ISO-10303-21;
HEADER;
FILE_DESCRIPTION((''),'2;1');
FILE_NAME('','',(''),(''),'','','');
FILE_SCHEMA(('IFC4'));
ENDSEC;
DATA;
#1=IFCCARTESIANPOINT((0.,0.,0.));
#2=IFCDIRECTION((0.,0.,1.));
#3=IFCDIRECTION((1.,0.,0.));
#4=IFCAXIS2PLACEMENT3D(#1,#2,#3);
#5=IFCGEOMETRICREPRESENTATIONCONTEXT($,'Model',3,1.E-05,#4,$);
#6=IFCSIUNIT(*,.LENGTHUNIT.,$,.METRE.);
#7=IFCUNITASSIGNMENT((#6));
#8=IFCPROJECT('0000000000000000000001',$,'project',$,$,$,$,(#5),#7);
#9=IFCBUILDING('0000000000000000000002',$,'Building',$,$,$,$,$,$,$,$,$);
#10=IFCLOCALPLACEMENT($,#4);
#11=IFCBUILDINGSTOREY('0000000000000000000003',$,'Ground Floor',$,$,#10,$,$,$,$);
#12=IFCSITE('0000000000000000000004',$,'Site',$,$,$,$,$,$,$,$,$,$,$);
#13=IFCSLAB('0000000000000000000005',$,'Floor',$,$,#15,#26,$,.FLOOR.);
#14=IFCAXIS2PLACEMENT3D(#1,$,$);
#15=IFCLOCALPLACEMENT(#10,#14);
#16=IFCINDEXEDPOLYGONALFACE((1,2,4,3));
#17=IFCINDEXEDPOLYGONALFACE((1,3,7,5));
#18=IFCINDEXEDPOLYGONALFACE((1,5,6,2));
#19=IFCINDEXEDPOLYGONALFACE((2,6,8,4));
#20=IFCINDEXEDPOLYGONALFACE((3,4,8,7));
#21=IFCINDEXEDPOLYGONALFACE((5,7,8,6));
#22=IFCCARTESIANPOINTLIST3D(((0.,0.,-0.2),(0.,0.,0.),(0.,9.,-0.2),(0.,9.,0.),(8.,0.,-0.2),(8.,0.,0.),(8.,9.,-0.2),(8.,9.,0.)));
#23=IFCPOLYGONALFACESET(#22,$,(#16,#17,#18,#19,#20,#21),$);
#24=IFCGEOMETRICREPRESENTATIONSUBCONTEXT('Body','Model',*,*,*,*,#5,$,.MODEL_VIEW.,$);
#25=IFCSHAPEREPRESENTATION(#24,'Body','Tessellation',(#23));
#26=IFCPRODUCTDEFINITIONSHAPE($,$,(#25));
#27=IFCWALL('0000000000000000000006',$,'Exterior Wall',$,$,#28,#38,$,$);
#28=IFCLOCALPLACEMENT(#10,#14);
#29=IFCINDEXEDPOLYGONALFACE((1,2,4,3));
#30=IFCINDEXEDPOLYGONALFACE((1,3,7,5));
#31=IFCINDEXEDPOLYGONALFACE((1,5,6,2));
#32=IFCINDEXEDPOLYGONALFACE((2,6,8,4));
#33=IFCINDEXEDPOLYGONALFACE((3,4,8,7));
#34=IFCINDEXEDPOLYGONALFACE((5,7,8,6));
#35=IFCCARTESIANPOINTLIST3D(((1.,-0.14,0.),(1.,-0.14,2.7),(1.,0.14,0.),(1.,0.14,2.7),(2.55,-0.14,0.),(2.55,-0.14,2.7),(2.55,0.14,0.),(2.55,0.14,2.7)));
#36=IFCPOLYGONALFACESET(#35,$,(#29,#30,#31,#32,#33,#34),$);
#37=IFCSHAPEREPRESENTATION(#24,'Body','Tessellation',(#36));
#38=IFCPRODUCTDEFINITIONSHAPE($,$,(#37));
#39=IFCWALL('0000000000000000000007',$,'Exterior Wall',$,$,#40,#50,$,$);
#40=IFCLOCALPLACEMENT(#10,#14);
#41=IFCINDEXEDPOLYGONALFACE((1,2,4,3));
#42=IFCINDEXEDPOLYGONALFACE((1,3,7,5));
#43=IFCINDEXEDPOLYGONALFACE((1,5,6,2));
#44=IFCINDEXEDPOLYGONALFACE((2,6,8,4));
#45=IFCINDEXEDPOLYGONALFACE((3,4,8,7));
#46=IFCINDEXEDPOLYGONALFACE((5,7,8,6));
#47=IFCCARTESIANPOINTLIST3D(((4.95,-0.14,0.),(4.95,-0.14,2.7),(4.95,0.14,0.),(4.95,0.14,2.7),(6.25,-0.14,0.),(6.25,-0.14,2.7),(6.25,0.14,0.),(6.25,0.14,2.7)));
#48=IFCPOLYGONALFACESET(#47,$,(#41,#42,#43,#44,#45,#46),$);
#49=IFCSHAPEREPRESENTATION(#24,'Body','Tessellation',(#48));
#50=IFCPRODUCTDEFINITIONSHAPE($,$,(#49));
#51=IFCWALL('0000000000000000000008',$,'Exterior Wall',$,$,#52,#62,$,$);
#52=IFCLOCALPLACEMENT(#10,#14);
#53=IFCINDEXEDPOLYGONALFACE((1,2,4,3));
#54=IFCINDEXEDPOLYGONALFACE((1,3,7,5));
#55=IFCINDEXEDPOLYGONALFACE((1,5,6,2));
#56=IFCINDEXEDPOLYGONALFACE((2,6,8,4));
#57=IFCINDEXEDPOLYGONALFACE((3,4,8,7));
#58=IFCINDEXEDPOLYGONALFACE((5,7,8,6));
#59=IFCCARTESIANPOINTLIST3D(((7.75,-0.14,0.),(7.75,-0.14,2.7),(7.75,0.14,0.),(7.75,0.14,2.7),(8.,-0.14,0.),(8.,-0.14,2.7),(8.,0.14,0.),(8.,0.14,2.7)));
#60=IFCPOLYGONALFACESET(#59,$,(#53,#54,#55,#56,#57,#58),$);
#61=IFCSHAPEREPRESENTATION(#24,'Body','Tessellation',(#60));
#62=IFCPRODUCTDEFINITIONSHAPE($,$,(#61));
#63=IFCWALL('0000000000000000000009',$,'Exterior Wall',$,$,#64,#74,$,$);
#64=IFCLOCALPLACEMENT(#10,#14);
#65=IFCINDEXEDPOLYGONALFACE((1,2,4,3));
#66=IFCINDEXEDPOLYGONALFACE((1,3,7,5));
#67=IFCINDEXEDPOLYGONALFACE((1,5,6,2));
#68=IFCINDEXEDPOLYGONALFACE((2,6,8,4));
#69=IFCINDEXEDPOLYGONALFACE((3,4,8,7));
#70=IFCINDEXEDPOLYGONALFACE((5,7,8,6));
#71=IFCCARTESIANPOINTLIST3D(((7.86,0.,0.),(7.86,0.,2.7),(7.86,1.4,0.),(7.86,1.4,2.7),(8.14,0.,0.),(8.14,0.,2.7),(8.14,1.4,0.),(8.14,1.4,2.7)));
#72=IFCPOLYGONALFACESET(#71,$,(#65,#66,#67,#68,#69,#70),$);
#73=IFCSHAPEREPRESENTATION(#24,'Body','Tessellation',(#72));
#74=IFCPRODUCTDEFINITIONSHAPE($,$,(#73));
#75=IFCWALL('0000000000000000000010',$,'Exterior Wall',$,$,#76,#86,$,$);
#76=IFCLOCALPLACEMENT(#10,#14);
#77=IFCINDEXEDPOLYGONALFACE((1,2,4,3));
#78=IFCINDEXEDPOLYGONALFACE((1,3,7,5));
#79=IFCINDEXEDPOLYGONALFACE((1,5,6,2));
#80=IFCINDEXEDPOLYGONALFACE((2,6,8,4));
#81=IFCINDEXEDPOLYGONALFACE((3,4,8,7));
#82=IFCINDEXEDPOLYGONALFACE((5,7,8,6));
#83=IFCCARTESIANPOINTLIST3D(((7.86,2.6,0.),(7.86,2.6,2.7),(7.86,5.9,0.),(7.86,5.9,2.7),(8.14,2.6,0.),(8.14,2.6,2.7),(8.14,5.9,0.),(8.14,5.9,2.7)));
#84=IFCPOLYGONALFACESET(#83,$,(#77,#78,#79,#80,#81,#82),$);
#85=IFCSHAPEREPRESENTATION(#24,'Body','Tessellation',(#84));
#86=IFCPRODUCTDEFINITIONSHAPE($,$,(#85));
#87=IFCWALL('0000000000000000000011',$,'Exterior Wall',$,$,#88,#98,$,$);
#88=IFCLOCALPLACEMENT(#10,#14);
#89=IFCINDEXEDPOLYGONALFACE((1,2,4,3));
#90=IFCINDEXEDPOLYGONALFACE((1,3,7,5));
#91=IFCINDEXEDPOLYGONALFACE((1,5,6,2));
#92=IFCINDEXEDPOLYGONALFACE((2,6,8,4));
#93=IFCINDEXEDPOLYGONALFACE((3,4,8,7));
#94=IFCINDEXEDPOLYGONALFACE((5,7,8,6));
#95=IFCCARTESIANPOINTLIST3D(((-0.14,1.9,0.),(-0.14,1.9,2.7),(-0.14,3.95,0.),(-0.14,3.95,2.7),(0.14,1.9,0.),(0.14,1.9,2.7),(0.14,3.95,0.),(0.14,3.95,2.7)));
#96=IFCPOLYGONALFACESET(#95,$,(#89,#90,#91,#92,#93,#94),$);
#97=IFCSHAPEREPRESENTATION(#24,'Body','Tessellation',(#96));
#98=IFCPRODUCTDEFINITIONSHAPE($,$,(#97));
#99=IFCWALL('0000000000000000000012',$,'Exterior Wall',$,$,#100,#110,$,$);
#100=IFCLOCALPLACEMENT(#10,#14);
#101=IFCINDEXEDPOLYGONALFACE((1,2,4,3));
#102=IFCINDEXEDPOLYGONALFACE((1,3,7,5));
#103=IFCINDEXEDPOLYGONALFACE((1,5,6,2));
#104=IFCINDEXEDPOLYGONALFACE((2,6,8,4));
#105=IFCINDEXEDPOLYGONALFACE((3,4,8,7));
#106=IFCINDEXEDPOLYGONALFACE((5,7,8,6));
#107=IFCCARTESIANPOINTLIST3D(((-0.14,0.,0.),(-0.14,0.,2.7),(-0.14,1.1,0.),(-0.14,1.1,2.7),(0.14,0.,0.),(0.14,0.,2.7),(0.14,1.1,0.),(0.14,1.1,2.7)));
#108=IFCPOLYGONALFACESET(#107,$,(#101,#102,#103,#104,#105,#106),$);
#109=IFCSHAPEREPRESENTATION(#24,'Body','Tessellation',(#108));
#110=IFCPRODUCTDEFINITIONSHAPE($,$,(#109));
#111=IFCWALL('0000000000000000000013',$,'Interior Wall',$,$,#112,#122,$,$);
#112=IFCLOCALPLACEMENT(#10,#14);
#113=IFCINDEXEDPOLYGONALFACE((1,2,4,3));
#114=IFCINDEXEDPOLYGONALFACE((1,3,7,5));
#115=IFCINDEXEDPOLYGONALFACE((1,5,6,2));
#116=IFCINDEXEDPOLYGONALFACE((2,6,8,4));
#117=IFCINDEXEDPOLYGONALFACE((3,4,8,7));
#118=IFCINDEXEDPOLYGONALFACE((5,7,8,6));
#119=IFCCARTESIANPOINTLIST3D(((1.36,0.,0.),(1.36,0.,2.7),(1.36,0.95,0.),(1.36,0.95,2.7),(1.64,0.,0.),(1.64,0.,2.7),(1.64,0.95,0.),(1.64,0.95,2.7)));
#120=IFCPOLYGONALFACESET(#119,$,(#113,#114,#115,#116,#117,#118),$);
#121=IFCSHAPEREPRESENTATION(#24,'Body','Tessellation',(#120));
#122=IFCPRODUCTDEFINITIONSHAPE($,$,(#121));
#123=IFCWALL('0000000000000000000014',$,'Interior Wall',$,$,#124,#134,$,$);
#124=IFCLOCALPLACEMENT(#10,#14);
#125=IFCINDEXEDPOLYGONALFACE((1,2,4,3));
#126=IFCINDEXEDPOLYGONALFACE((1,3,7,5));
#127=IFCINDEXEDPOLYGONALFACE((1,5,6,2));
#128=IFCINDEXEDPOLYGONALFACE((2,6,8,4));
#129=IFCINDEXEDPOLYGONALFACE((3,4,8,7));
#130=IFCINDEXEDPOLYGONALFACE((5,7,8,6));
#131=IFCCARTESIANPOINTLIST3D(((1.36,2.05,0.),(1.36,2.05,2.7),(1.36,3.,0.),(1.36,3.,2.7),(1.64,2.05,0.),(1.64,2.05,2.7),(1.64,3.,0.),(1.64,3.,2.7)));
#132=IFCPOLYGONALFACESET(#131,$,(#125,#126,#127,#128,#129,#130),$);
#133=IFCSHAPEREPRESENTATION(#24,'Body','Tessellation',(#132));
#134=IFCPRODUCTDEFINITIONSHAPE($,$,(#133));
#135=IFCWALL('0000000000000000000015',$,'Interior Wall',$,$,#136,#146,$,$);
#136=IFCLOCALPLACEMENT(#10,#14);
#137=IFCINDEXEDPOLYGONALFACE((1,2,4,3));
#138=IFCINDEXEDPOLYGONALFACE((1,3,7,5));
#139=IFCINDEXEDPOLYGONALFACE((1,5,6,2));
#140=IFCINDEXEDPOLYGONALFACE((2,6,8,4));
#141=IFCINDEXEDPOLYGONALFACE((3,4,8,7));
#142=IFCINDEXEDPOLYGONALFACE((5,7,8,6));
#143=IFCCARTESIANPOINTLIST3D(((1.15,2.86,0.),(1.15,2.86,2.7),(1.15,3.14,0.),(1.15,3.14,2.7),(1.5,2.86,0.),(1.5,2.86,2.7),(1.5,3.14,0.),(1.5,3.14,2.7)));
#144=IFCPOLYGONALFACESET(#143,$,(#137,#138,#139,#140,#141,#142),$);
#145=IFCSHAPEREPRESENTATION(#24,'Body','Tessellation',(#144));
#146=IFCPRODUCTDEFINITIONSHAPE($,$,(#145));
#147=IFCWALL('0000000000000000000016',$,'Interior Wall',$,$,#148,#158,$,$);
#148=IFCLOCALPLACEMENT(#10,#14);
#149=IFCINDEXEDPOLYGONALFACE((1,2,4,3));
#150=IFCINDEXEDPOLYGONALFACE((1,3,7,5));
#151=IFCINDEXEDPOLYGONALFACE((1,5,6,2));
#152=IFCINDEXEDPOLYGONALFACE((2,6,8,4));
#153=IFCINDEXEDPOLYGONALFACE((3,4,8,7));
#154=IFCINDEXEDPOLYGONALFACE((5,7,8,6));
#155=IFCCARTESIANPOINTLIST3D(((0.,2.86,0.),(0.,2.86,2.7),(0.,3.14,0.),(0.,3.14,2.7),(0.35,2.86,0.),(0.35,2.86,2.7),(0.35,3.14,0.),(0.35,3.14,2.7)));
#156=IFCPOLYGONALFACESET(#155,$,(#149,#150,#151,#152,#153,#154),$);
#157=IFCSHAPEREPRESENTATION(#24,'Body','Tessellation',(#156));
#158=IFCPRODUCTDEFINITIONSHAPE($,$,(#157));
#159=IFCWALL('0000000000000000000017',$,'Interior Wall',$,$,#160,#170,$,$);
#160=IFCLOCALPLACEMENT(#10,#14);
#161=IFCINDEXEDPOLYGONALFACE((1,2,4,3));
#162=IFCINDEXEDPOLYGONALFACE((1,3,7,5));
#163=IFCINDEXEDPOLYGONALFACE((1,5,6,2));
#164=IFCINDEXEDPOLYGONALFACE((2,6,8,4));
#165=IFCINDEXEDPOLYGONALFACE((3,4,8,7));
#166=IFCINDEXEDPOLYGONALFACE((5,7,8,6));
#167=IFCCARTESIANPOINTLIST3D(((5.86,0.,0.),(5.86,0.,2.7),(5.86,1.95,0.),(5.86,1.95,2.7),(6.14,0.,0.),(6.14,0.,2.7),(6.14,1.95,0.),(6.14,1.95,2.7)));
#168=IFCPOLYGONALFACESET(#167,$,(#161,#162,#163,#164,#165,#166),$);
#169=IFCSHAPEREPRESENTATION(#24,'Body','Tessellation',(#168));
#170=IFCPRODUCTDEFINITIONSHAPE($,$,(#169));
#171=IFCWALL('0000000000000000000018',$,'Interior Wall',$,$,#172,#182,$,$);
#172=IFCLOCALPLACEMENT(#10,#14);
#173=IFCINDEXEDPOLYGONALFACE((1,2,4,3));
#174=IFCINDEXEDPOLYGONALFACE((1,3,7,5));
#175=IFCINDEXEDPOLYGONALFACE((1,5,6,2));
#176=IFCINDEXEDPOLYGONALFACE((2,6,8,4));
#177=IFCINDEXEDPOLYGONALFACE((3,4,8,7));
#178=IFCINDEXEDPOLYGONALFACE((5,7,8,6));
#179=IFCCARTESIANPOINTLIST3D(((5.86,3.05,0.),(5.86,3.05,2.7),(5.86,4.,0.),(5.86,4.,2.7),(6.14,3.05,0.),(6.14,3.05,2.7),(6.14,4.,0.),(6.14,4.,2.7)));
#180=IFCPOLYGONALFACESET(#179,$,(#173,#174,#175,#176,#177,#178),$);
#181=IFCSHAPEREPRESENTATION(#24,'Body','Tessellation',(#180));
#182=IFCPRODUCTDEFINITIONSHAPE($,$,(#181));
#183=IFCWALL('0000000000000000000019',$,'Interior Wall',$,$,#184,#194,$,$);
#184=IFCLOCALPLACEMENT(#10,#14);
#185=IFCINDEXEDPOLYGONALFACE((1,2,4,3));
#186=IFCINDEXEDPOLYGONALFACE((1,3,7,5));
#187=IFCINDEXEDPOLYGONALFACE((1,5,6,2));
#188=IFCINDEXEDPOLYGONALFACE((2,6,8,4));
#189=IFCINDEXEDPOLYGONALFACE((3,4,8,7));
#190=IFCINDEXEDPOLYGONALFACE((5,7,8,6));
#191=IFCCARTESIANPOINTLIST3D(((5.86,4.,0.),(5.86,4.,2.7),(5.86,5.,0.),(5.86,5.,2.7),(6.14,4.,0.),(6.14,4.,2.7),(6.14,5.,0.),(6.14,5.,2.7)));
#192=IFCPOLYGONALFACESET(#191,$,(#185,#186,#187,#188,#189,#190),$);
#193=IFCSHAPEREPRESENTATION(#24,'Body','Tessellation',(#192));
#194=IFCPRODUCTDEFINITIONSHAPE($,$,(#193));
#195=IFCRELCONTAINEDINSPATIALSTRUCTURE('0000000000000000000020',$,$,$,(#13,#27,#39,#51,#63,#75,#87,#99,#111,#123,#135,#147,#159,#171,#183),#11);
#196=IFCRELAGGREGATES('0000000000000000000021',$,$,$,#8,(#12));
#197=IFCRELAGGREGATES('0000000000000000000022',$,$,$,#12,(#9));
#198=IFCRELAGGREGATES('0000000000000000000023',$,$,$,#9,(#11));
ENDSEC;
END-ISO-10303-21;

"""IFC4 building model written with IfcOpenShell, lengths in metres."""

from ifc_helpers import new_model, si_unit, frame, origin_with_axes, place, context, subcontext, project, spatial, indexed_curve, outline, extrude, element, save


model = new_model("IFC4")

# Units and contexts
model_context = context("Model", 3, precision=1e-05, world=origin_with_axes())
body_context = subcontext(model_context, "Body", "Model", "MODEL_VIEW")
ifc_project = project(units=[si_unit("LENGTHUNIT", "METRE")], contexts=[model_context])

# Site, building, storey
site = spatial("IfcSite", under=ifc_project, Name="Site")
building = spatial("IfcBuilding", under=site, Name="Building")
storey_placement = place(None, origin_with_axes())
storey = spatial("IfcBuildingStorey", under=building, at=storey_placement, Name="Ground Floor")

# Slab
slab_placement = place(storey_placement, frame((0.0, 0.0, -0.2), z_axis=(0.0, 0.0, 1.0), x_axis=(1.0, 0.0, 0.0)))
element("IfcSlab", 1, at=slab_placement, inside=storey, Name="Floor", PredefinedType="FLOOR", context=body_context, shape_type="SweptSolid", body=[
    extrude(outline(indexed_curve([(0.0, 0.0), (8.0, 0.0), (8.0, 9.0), (0.0, 9.0)])), None, (0.0, 0.0, 1.0), 0.2),
])

# Walls
wall_1_placement = place(storey_placement, frame((1.0, 0.0, 0.0), z_axis=(0.0, 0.0, 1.0), x_axis=(1.0, 0.0, 0.0)))
element("IfcWall", 2, at=wall_1_placement, inside=storey, Name="Exterior Wall", context=body_context, shape_type="SweptSolid", body=[
    extrude(outline(indexed_curve([(0.0, 0.0), (0.0, 0.28), (1.55, 0.28), (1.55, 0.0), (0.0, 0.0)], self_intersect=False)), frame((0.0, -0.14, 0.0), z_axis=(0.0, 0.0, 1.0), x_axis=(1.0, 0.0, 0.0)), (0.0, 0.0, 1.0), 2.7),
])
wall_2_placement = place(storey_placement, frame((4.95, 0.0, 0.0), z_axis=(0.0, 0.0, 1.0), x_axis=(1.0, 0.0, 0.0)))
element("IfcWall", 3, at=wall_2_placement, inside=storey, Name="Exterior Wall", context=body_context, shape_type="SweptSolid", body=[
    extrude(outline(indexed_curve([(0.0, 0.0), (0.0, 0.28), (1.3, 0.28), (1.3, 0.0), (0.0, 0.0)], self_intersect=False)), frame((0.0, -0.14, 0.0), z_axis=(0.0, 0.0, 1.0), x_axis=(1.0, 0.0, 0.0)), (0.0, 0.0, 1.0), 2.7),
])
wall_3_placement = place(storey_placement, frame((7.75, 0.0, 0.0), z_axis=(0.0, 0.0, 1.0), x_axis=(1.0, 0.0, 0.0)))
element("IfcWall", 4, at=wall_3_placement, inside=storey, Name="Exterior Wall", context=body_context, shape_type="SweptSolid", body=[
    extrude(outline(indexed_curve([(0.0, 0.0), (0.0, 0.28), (0.25, 0.28), (0.25, 0.0), (0.0, 0.0)], self_intersect=False)), frame((0.0, -0.14, 0.0), z_axis=(0.0, 0.0, 1.0), x_axis=(1.0, 0.0, 0.0)), (0.0, 0.0, 1.0), 2.7),
])
wall_4_placement = place(storey_placement, frame((8.0, 0.0, 0.0), z_axis=(0.0, 0.0, 1.0), x_axis=(0.0, 1.0, 0.0)))
element("IfcWall", 5, at=wall_4_placement, inside=storey, Name="Exterior Wall", context=body_context, shape_type="SweptSolid", body=[
    extrude(outline(indexed_curve([(0.0, 0.0), (0.0, 0.28), (1.4, 0.28), (1.4, 0.0), (0.0, 0.0)], self_intersect=False)), frame((0.0, -0.14, 0.0), z_axis=(0.0, 0.0, 1.0), x_axis=(1.0, 0.0, 0.0)), (0.0, 0.0, 1.0), 2.7),
])
wall_5_placement = place(storey_placement, frame((8.0, 2.6, 0.0), z_axis=(0.0, 0.0, 1.0), x_axis=(0.0, 1.0, 0.0)))
element("IfcWall", 6, at=wall_5_placement, inside=storey, Name="Exterior Wall", context=body_context, shape_type="SweptSolid", body=[
    extrude(outline(indexed_curve([(0.0, 0.0), (0.0, 0.28), (3.3, 0.28), (3.3, 0.0), (0.0, 0.0)], self_intersect=False)), frame((0.0, -0.14, 0.0), z_axis=(0.0, 0.0, 1.0), x_axis=(1.0, 0.0, 0.0)), (0.0, 0.0, 1.0), 2.7),
])
wall_6_placement = place(storey_placement, frame((0.0, 3.95, 0.0), z_axis=(0.0, 0.0, 1.0), x_axis=(0.0, -1.0, 0.0)))
element("IfcWall", 7, at=wall_6_placement, inside=storey, Name="Exterior Wall", context=body_context, shape_type="SweptSolid", body=[
    extrude(outline(indexed_curve([(0.0, 0.0), (0.0, 0.28), (2.05, 0.28), (2.05, 0.0), (0.0, 0.0)], self_intersect=False)), frame((0.0, -0.14, 0.0), z_axis=(0.0, 0.0, 1.0), x_axis=(1.0, 0.0, 0.0)), (0.0, 0.0, 1.0), 2.7),
])
wall_7_placement = place(storey_placement, frame((0.0, 1.1, 0.0), z_axis=(0.0, 0.0, 1.0), x_axis=(0.0, -1.0, 0.0)))
element("IfcWall", 8, at=wall_7_placement, inside=storey, Name="Exterior Wall", context=body_context, shape_type="SweptSolid", body=[
    extrude(outline(indexed_curve([(0.0, 0.0), (0.0, 0.28), (1.1, 0.28), (1.1, 0.0), (0.0, 0.0)], self_intersect=False)), frame((0.0, -0.14, 0.0), z_axis=(0.0, 0.0, 1.0), x_axis=(1.0, 0.0, 0.0)), (0.0, 0.0, 1.0), 2.7),
])
wall_8_placement = place(storey_placement, frame((1.5, 0.0, 0.0), z_axis=(0.0, 0.0, 1.0), x_axis=(0.0, 1.0, 0.0)))
element("IfcWall", 9, at=wall_8_placement, inside=storey, Name="Interior Wall", context=body_context, shape_type="SweptSolid", body=[
    extrude(outline(indexed_curve([(0.0, 0.0), (0.0, 0.28), (0.95, 0.28), (0.95, 0.0), (0.0, 0.0)], self_intersect=False)), frame((0.0, -0.14, 0.0), z_axis=(0.0, 0.0, 1.0), x_axis=(1.0, 0.0, 0.0)), (0.0, 0.0, 1.0), 2.7),
])
wall_9_placement = place(storey_placement, frame((1.5, 2.05, 0.0), z_axis=(0.0, 0.0, 1.0), x_axis=(0.0, 1.0, 0.0)))
element("IfcWall", 10, at=wall_9_placement, inside=storey, Name="Interior Wall", context=body_context, shape_type="SweptSolid", body=[
    extrude(outline(indexed_curve([(0.0, 0.0), (0.0, 0.28), (0.95, 0.28), (0.95, 0.0), (0.0, 0.0)], self_intersect=False)), frame((0.0, -0.14, 0.0), z_axis=(0.0, 0.0, 1.0), x_axis=(1.0, 0.0, 0.0)), (0.0, 0.0, 1.0), 2.7),
])
for number, where, z_axis, x_axis, name in (
    (11, (1.5, 3.0, 0.0), (0.0, 0.0, 1.0), (-1.0, 0.0, 0.0), "Interior Wall"),
    (12, (0.35, 3.0, 0.0), (0.0, 0.0, 1.0), (-1.0, 0.0, 0.0), "Interior Wall"),
):
    element("IfcWall", number, at=place(storey_placement, frame(where, z_axis=z_axis, x_axis=x_axis)), inside=storey, Name=name, context=body_context, shape_type="SweptSolid", body=[
        extrude(outline(indexed_curve([(0.0, 0.0), (0.0, 0.28), (0.35, 0.28), (0.35, 0.0), (0.0, 0.0)], self_intersect=False)), frame((0.0, -0.14, 0.0), z_axis=(0.0, 0.0, 1.0), x_axis=(1.0, 0.0, 0.0)), (0.0, 0.0, 1.0), 2.7),
    ])
wall_10_placement = place(storey_placement, frame((6.0, 0.0, 0.0), z_axis=(0.0, 0.0, 1.0), x_axis=(0.0, 1.0, 0.0)))
element("IfcWall", 13, at=wall_10_placement, inside=storey, Name="Interior Wall", context=body_context, shape_type="SweptSolid", body=[
    extrude(outline(indexed_curve([(0.0, 0.0), (0.0, 0.28), (1.95, 0.28), (1.95, 0.0), (0.0, 0.0)], self_intersect=False)), frame((0.0, -0.14, 0.0), z_axis=(0.0, 0.0, 1.0), x_axis=(1.0, 0.0, 0.0)), (0.0, 0.0, 1.0), 2.7),
])
wall_11_placement = place(storey_placement, frame((6.0, 3.05, 0.0), z_axis=(0.0, 0.0, 1.0), x_axis=(0.0, 1.0, 0.0)))
element("IfcWall", 14, at=wall_11_placement, inside=storey, Name="Interior Wall", context=body_context, shape_type="SweptSolid", body=[
    extrude(outline(indexed_curve([(0.0, 0.0), (0.0, 0.28), (0.95, 0.28), (0.95, 0.0), (0.0, 0.0)], self_intersect=False)), frame((0.0, -0.14, 0.0), z_axis=(0.0, 0.0, 1.0), x_axis=(1.0, 0.0, 0.0)), (0.0, 0.0, 1.0), 2.7),
])
wall_12_placement = place(storey_placement, frame((6.0, 4.0, 0.0), z_axis=(0.0, 0.0, 1.0), x_axis=(0.0, 1.0, 0.0)))
element("IfcWall", 15, at=wall_12_placement, inside=storey, Name="Interior Wall", context=body_context, shape_type="SweptSolid", body=[
    extrude(outline(indexed_curve([(0.0, 0.0), (0.0, 0.28), (1.0, 0.28), (1.0, 0.0), (0.0, 0.0)], self_intersect=False)), frame((0.0, -0.14, 0.0), z_axis=(0.0, 0.0, 1.0), x_axis=(1.0, 0.0, 0.0)), (0.0, 0.0, 1.0), 2.7),
])

save(model, "model.ifc")
